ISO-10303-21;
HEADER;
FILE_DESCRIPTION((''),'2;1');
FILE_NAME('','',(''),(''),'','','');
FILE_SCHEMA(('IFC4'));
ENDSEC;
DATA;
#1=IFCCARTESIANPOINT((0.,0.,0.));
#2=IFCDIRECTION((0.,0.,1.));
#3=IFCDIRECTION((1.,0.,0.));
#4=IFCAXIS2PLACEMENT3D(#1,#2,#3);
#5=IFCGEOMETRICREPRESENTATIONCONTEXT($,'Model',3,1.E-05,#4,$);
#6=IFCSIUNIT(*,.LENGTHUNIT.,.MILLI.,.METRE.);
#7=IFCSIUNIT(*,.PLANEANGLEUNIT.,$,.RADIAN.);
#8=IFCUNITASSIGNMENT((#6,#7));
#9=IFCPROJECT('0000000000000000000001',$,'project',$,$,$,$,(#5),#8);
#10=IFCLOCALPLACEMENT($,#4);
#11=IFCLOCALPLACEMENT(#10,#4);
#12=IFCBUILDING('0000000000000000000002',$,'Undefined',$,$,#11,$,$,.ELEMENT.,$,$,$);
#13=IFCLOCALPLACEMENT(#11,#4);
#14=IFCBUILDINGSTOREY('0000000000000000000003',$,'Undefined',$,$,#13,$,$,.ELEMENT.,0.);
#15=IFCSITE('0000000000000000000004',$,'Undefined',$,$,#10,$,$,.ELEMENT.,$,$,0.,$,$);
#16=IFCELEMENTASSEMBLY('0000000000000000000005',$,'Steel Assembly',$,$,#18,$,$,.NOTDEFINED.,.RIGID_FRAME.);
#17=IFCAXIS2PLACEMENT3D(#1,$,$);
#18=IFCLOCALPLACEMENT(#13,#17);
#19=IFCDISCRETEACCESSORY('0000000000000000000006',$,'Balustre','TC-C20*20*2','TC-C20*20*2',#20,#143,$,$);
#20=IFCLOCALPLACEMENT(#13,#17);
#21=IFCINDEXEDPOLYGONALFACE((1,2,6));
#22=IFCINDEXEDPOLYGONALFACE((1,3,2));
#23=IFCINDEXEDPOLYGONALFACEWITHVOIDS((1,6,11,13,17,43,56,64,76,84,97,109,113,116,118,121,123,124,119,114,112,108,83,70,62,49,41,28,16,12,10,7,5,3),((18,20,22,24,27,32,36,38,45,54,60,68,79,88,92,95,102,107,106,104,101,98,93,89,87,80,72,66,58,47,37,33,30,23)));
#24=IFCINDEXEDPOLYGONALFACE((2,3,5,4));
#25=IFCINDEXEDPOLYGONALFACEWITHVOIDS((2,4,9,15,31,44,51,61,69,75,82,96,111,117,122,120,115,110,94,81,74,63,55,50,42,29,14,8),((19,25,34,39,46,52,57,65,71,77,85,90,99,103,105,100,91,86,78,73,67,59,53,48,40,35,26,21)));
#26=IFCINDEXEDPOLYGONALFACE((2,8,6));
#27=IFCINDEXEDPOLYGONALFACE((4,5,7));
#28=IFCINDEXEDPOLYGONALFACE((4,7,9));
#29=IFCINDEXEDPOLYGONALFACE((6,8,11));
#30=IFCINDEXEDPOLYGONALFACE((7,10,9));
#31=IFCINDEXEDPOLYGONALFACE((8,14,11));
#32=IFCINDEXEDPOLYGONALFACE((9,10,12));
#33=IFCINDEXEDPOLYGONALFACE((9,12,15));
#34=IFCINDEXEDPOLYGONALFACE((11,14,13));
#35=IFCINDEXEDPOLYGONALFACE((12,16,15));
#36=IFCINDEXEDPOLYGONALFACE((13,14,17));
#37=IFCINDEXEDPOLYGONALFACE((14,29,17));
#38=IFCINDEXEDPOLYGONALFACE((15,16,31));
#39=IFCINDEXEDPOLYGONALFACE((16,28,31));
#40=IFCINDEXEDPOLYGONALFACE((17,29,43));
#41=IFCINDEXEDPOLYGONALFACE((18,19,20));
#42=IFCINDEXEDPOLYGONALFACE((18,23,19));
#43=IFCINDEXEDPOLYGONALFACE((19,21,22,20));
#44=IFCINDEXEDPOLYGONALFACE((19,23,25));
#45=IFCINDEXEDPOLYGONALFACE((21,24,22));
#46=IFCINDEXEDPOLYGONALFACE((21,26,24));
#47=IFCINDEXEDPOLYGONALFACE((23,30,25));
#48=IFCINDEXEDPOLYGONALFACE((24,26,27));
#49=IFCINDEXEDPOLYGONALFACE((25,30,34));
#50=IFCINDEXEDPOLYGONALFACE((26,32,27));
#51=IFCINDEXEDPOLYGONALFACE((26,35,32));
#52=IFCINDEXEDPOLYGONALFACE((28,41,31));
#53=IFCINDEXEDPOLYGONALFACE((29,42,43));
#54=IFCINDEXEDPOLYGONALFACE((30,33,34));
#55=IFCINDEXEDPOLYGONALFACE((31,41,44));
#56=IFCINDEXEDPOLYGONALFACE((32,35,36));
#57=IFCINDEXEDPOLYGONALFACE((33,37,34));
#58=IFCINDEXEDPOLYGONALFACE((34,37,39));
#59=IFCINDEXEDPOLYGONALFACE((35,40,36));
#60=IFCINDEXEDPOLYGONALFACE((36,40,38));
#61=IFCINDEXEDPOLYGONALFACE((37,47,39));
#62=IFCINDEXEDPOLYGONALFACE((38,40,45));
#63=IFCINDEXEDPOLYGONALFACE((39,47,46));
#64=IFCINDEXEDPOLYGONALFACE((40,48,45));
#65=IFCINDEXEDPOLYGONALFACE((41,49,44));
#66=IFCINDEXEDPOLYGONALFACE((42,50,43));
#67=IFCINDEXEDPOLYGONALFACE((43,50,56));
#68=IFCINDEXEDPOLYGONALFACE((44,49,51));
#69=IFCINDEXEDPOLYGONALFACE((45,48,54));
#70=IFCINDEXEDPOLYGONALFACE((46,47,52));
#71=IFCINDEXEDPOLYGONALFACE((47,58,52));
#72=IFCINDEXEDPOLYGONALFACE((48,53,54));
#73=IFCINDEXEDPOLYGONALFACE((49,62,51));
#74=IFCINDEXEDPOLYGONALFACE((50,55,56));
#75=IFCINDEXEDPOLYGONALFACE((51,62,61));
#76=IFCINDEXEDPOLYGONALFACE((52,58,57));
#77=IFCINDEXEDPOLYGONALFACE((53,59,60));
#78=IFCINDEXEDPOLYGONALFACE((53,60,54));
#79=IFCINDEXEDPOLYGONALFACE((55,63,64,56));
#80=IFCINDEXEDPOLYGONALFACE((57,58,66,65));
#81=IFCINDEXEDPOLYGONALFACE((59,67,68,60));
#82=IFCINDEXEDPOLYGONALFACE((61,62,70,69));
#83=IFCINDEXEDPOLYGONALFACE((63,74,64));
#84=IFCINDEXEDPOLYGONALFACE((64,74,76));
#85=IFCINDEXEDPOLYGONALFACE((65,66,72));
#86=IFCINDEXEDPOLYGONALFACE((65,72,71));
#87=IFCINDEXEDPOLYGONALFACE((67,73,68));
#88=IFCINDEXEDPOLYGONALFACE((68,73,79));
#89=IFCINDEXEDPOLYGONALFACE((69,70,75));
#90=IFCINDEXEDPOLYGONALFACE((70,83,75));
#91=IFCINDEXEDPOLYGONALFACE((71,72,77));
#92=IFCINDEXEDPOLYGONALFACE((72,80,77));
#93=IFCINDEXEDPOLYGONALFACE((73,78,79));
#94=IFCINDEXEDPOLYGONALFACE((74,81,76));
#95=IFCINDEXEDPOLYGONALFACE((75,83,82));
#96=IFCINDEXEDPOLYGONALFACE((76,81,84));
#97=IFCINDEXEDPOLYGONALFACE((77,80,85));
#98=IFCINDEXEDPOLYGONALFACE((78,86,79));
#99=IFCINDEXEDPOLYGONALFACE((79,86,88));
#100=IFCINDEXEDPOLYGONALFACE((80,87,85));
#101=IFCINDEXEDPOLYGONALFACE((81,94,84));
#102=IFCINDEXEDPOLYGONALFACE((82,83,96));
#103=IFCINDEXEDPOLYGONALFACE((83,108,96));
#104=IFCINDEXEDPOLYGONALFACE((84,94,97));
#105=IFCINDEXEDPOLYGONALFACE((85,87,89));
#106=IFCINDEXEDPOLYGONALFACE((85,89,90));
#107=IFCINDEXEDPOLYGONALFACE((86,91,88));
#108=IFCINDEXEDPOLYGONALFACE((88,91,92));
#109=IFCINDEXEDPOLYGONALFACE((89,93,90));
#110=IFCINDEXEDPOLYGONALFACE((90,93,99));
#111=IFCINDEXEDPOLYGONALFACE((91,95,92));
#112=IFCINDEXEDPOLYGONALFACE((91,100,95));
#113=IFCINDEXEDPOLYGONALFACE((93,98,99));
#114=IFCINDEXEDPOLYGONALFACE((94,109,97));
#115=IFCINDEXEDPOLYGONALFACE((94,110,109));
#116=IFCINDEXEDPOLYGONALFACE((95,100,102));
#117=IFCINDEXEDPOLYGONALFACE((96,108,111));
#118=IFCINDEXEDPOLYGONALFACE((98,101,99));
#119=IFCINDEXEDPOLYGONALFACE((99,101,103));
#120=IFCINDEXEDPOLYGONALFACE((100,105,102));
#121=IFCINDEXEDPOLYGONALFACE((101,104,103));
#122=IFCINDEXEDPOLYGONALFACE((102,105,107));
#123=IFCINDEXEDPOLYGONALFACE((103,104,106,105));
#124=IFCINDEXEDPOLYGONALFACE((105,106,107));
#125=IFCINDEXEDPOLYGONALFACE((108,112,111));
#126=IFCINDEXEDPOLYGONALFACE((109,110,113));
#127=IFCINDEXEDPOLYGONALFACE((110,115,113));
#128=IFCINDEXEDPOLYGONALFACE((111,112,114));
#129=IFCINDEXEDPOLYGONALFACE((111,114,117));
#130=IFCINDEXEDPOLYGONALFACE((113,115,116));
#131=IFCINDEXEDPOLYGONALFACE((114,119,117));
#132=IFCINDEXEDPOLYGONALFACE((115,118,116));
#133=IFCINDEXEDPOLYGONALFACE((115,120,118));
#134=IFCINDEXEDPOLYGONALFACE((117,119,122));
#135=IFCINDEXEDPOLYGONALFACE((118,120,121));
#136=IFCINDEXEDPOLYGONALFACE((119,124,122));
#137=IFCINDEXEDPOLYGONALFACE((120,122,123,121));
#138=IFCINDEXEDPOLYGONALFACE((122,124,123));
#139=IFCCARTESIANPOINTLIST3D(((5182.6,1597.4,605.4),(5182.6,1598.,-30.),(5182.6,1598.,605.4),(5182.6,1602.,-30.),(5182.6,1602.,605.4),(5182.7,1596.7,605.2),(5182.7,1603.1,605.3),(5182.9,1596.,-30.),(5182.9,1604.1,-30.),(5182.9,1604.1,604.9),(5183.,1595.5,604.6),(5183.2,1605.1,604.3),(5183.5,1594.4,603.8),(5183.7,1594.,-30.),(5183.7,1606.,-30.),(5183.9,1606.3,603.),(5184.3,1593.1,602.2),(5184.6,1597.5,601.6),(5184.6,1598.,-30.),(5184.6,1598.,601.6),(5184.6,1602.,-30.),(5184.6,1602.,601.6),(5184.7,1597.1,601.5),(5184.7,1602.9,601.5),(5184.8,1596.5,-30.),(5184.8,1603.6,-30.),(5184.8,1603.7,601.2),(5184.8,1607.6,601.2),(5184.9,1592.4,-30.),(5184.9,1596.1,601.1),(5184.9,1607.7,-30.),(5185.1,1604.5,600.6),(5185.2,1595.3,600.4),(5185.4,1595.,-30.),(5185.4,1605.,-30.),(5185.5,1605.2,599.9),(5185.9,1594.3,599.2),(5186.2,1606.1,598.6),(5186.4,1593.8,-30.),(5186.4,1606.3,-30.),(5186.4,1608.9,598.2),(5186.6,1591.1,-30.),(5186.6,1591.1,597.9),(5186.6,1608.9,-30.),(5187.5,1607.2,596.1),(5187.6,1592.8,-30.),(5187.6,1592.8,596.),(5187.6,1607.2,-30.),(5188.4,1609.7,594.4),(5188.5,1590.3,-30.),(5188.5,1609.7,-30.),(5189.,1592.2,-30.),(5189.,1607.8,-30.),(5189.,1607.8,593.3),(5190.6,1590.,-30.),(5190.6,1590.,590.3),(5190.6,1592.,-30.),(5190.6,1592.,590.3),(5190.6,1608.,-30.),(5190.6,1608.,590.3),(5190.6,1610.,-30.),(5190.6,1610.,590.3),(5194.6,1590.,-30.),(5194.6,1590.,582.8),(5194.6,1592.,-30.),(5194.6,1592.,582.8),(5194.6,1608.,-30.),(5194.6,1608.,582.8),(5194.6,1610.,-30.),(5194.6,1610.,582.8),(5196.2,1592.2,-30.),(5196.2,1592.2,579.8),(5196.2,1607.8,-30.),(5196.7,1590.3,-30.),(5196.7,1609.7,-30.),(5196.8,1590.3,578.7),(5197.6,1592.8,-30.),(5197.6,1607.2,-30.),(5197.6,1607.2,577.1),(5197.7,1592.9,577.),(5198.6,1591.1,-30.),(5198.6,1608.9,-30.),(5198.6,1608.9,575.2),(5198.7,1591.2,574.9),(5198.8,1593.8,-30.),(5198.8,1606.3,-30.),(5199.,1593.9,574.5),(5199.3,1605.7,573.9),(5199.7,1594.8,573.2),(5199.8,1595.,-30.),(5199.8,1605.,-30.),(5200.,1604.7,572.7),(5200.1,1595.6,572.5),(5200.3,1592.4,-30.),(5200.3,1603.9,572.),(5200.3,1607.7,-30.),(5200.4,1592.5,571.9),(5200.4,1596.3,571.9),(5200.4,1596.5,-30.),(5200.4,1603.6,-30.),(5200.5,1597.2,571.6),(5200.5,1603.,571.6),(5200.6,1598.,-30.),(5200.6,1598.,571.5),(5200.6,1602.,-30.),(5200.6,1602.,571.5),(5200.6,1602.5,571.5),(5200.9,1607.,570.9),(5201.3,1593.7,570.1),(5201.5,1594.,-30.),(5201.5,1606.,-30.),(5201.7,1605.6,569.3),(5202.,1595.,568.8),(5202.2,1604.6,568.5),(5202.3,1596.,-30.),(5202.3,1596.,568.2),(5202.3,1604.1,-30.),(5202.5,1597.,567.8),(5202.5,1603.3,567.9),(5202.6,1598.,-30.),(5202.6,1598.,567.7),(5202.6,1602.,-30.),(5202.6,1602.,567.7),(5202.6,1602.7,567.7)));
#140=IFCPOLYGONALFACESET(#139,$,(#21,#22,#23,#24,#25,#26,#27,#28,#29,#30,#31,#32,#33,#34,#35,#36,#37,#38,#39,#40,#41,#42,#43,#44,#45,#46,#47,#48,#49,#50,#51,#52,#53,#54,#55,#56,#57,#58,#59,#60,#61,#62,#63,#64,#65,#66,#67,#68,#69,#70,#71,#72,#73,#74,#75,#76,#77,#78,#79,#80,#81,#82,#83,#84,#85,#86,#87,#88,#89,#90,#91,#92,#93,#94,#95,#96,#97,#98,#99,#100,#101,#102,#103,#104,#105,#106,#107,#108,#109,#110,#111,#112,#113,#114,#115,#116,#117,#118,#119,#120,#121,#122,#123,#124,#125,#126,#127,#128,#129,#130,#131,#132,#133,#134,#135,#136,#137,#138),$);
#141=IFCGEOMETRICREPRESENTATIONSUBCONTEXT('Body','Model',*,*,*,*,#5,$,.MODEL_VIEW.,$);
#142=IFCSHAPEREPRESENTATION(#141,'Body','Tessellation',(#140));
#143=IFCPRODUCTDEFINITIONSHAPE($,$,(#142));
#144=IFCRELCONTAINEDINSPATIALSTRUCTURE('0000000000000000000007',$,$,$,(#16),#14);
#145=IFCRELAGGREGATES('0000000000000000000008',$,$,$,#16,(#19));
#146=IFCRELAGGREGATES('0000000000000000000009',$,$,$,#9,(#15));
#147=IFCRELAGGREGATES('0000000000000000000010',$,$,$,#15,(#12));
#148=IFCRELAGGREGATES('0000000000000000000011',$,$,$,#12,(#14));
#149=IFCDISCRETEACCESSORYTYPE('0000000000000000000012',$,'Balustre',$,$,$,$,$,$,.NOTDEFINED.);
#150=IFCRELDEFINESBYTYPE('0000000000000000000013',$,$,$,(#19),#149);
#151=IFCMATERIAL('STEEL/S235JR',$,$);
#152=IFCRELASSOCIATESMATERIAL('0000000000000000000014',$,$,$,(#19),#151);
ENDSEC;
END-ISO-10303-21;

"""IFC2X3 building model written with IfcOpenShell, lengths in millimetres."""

from ifc_helpers import new_model, si_unit, frame, origin_with_axes, origin_2d_with_axis, place, context, subcontext, project, spatial, hollow_rectangle, extrude, clip, halfspace, material, type_object, element, aggregate, save


model = new_model("IFC2X3")

# Units and contexts
model_context = context("Model", 3, precision=1e-05, world=origin_with_axes())
body_context = subcontext(model_context, "Body", "Model", "MODEL_VIEW")
ifc_project = project(units=[si_unit("LENGTHUNIT", "METRE", prefix="MILLI"), si_unit("PLANEANGLEUNIT", "RADIAN")], contexts=[model_context])

# Site, building, storey
site_placement = place(None, origin_with_axes())
site = spatial("IfcSite", under=ifc_project, at=site_placement, Name="Undefined", CompositionType="ELEMENT", RefElevation=0.0)
building_placement = place(site_placement, origin_with_axes())
building = spatial("IfcBuilding", under=site, at=building_placement, Name="Undefined", CompositionType="ELEMENT")
storey_placement = place(building_placement, origin_with_axes())
storey = spatial("IfcBuildingStorey", under=building, at=storey_placement, Name="Undefined", CompositionType="ELEMENT", Elevation=0.0)

# Shared definitions
ifc_material = material(Name="STEEL/S235JR")

# Element assembly, discrete accessory
assembly_1_placement = place(storey_placement, origin_with_axes())
assembly_1 = element("IfcElementAssembly", 1, at=assembly_1_placement, inside=storey, Name="Steel Assembly", AssemblyPlace="NOTDEFINED", PredefinedType="RIGID_FRAME")
discrete_accessory_type_1 = type_object("IfcDiscreteAccessoryType", Name="Balustre")
discrete_accessory_1_placement = place(assembly_1_placement, frame((5192.6, 1600.0, -30.0), z_axis=(0.0, 0.0, 1.0), x_axis=(1.0, 0.0, 0.0)))
discrete_accessory_1 = element("IfcDiscreteAccessory", 2, at=discrete_accessory_1_placement, type_object=discrete_accessory_type_1, material=ifc_material, Name="Balustre", Description="TC-C20*20*2", ObjectType="TC-C20*20*2", context=body_context, shape_type="Clipping", body=[
    clip(extrude(hollow_rectangle(XDim=20.0, YDim=20.0, WallThickness=2.0, InnerFilletRadius=6.0, OuterFilletRadius=8.0, at=origin_2d_with_axis()), frame((0.0, 0.0, 635.6), z_axis=(0.0, 0.0, -1.0), x_axis=(-1.0, -0.000011, 0.0)), (0.0, 0.0, 1.0), 635.6), halfspace(frame((175.6, 0.0, 285.4), z_axis=(-0.883506, -0.000005, -0.46842), x_axis=(-0.000005, 1.0, 0.0)), True)),
])

aggregate(assembly_1, [discrete_accessory_1])

save(model, "model.ifc")
